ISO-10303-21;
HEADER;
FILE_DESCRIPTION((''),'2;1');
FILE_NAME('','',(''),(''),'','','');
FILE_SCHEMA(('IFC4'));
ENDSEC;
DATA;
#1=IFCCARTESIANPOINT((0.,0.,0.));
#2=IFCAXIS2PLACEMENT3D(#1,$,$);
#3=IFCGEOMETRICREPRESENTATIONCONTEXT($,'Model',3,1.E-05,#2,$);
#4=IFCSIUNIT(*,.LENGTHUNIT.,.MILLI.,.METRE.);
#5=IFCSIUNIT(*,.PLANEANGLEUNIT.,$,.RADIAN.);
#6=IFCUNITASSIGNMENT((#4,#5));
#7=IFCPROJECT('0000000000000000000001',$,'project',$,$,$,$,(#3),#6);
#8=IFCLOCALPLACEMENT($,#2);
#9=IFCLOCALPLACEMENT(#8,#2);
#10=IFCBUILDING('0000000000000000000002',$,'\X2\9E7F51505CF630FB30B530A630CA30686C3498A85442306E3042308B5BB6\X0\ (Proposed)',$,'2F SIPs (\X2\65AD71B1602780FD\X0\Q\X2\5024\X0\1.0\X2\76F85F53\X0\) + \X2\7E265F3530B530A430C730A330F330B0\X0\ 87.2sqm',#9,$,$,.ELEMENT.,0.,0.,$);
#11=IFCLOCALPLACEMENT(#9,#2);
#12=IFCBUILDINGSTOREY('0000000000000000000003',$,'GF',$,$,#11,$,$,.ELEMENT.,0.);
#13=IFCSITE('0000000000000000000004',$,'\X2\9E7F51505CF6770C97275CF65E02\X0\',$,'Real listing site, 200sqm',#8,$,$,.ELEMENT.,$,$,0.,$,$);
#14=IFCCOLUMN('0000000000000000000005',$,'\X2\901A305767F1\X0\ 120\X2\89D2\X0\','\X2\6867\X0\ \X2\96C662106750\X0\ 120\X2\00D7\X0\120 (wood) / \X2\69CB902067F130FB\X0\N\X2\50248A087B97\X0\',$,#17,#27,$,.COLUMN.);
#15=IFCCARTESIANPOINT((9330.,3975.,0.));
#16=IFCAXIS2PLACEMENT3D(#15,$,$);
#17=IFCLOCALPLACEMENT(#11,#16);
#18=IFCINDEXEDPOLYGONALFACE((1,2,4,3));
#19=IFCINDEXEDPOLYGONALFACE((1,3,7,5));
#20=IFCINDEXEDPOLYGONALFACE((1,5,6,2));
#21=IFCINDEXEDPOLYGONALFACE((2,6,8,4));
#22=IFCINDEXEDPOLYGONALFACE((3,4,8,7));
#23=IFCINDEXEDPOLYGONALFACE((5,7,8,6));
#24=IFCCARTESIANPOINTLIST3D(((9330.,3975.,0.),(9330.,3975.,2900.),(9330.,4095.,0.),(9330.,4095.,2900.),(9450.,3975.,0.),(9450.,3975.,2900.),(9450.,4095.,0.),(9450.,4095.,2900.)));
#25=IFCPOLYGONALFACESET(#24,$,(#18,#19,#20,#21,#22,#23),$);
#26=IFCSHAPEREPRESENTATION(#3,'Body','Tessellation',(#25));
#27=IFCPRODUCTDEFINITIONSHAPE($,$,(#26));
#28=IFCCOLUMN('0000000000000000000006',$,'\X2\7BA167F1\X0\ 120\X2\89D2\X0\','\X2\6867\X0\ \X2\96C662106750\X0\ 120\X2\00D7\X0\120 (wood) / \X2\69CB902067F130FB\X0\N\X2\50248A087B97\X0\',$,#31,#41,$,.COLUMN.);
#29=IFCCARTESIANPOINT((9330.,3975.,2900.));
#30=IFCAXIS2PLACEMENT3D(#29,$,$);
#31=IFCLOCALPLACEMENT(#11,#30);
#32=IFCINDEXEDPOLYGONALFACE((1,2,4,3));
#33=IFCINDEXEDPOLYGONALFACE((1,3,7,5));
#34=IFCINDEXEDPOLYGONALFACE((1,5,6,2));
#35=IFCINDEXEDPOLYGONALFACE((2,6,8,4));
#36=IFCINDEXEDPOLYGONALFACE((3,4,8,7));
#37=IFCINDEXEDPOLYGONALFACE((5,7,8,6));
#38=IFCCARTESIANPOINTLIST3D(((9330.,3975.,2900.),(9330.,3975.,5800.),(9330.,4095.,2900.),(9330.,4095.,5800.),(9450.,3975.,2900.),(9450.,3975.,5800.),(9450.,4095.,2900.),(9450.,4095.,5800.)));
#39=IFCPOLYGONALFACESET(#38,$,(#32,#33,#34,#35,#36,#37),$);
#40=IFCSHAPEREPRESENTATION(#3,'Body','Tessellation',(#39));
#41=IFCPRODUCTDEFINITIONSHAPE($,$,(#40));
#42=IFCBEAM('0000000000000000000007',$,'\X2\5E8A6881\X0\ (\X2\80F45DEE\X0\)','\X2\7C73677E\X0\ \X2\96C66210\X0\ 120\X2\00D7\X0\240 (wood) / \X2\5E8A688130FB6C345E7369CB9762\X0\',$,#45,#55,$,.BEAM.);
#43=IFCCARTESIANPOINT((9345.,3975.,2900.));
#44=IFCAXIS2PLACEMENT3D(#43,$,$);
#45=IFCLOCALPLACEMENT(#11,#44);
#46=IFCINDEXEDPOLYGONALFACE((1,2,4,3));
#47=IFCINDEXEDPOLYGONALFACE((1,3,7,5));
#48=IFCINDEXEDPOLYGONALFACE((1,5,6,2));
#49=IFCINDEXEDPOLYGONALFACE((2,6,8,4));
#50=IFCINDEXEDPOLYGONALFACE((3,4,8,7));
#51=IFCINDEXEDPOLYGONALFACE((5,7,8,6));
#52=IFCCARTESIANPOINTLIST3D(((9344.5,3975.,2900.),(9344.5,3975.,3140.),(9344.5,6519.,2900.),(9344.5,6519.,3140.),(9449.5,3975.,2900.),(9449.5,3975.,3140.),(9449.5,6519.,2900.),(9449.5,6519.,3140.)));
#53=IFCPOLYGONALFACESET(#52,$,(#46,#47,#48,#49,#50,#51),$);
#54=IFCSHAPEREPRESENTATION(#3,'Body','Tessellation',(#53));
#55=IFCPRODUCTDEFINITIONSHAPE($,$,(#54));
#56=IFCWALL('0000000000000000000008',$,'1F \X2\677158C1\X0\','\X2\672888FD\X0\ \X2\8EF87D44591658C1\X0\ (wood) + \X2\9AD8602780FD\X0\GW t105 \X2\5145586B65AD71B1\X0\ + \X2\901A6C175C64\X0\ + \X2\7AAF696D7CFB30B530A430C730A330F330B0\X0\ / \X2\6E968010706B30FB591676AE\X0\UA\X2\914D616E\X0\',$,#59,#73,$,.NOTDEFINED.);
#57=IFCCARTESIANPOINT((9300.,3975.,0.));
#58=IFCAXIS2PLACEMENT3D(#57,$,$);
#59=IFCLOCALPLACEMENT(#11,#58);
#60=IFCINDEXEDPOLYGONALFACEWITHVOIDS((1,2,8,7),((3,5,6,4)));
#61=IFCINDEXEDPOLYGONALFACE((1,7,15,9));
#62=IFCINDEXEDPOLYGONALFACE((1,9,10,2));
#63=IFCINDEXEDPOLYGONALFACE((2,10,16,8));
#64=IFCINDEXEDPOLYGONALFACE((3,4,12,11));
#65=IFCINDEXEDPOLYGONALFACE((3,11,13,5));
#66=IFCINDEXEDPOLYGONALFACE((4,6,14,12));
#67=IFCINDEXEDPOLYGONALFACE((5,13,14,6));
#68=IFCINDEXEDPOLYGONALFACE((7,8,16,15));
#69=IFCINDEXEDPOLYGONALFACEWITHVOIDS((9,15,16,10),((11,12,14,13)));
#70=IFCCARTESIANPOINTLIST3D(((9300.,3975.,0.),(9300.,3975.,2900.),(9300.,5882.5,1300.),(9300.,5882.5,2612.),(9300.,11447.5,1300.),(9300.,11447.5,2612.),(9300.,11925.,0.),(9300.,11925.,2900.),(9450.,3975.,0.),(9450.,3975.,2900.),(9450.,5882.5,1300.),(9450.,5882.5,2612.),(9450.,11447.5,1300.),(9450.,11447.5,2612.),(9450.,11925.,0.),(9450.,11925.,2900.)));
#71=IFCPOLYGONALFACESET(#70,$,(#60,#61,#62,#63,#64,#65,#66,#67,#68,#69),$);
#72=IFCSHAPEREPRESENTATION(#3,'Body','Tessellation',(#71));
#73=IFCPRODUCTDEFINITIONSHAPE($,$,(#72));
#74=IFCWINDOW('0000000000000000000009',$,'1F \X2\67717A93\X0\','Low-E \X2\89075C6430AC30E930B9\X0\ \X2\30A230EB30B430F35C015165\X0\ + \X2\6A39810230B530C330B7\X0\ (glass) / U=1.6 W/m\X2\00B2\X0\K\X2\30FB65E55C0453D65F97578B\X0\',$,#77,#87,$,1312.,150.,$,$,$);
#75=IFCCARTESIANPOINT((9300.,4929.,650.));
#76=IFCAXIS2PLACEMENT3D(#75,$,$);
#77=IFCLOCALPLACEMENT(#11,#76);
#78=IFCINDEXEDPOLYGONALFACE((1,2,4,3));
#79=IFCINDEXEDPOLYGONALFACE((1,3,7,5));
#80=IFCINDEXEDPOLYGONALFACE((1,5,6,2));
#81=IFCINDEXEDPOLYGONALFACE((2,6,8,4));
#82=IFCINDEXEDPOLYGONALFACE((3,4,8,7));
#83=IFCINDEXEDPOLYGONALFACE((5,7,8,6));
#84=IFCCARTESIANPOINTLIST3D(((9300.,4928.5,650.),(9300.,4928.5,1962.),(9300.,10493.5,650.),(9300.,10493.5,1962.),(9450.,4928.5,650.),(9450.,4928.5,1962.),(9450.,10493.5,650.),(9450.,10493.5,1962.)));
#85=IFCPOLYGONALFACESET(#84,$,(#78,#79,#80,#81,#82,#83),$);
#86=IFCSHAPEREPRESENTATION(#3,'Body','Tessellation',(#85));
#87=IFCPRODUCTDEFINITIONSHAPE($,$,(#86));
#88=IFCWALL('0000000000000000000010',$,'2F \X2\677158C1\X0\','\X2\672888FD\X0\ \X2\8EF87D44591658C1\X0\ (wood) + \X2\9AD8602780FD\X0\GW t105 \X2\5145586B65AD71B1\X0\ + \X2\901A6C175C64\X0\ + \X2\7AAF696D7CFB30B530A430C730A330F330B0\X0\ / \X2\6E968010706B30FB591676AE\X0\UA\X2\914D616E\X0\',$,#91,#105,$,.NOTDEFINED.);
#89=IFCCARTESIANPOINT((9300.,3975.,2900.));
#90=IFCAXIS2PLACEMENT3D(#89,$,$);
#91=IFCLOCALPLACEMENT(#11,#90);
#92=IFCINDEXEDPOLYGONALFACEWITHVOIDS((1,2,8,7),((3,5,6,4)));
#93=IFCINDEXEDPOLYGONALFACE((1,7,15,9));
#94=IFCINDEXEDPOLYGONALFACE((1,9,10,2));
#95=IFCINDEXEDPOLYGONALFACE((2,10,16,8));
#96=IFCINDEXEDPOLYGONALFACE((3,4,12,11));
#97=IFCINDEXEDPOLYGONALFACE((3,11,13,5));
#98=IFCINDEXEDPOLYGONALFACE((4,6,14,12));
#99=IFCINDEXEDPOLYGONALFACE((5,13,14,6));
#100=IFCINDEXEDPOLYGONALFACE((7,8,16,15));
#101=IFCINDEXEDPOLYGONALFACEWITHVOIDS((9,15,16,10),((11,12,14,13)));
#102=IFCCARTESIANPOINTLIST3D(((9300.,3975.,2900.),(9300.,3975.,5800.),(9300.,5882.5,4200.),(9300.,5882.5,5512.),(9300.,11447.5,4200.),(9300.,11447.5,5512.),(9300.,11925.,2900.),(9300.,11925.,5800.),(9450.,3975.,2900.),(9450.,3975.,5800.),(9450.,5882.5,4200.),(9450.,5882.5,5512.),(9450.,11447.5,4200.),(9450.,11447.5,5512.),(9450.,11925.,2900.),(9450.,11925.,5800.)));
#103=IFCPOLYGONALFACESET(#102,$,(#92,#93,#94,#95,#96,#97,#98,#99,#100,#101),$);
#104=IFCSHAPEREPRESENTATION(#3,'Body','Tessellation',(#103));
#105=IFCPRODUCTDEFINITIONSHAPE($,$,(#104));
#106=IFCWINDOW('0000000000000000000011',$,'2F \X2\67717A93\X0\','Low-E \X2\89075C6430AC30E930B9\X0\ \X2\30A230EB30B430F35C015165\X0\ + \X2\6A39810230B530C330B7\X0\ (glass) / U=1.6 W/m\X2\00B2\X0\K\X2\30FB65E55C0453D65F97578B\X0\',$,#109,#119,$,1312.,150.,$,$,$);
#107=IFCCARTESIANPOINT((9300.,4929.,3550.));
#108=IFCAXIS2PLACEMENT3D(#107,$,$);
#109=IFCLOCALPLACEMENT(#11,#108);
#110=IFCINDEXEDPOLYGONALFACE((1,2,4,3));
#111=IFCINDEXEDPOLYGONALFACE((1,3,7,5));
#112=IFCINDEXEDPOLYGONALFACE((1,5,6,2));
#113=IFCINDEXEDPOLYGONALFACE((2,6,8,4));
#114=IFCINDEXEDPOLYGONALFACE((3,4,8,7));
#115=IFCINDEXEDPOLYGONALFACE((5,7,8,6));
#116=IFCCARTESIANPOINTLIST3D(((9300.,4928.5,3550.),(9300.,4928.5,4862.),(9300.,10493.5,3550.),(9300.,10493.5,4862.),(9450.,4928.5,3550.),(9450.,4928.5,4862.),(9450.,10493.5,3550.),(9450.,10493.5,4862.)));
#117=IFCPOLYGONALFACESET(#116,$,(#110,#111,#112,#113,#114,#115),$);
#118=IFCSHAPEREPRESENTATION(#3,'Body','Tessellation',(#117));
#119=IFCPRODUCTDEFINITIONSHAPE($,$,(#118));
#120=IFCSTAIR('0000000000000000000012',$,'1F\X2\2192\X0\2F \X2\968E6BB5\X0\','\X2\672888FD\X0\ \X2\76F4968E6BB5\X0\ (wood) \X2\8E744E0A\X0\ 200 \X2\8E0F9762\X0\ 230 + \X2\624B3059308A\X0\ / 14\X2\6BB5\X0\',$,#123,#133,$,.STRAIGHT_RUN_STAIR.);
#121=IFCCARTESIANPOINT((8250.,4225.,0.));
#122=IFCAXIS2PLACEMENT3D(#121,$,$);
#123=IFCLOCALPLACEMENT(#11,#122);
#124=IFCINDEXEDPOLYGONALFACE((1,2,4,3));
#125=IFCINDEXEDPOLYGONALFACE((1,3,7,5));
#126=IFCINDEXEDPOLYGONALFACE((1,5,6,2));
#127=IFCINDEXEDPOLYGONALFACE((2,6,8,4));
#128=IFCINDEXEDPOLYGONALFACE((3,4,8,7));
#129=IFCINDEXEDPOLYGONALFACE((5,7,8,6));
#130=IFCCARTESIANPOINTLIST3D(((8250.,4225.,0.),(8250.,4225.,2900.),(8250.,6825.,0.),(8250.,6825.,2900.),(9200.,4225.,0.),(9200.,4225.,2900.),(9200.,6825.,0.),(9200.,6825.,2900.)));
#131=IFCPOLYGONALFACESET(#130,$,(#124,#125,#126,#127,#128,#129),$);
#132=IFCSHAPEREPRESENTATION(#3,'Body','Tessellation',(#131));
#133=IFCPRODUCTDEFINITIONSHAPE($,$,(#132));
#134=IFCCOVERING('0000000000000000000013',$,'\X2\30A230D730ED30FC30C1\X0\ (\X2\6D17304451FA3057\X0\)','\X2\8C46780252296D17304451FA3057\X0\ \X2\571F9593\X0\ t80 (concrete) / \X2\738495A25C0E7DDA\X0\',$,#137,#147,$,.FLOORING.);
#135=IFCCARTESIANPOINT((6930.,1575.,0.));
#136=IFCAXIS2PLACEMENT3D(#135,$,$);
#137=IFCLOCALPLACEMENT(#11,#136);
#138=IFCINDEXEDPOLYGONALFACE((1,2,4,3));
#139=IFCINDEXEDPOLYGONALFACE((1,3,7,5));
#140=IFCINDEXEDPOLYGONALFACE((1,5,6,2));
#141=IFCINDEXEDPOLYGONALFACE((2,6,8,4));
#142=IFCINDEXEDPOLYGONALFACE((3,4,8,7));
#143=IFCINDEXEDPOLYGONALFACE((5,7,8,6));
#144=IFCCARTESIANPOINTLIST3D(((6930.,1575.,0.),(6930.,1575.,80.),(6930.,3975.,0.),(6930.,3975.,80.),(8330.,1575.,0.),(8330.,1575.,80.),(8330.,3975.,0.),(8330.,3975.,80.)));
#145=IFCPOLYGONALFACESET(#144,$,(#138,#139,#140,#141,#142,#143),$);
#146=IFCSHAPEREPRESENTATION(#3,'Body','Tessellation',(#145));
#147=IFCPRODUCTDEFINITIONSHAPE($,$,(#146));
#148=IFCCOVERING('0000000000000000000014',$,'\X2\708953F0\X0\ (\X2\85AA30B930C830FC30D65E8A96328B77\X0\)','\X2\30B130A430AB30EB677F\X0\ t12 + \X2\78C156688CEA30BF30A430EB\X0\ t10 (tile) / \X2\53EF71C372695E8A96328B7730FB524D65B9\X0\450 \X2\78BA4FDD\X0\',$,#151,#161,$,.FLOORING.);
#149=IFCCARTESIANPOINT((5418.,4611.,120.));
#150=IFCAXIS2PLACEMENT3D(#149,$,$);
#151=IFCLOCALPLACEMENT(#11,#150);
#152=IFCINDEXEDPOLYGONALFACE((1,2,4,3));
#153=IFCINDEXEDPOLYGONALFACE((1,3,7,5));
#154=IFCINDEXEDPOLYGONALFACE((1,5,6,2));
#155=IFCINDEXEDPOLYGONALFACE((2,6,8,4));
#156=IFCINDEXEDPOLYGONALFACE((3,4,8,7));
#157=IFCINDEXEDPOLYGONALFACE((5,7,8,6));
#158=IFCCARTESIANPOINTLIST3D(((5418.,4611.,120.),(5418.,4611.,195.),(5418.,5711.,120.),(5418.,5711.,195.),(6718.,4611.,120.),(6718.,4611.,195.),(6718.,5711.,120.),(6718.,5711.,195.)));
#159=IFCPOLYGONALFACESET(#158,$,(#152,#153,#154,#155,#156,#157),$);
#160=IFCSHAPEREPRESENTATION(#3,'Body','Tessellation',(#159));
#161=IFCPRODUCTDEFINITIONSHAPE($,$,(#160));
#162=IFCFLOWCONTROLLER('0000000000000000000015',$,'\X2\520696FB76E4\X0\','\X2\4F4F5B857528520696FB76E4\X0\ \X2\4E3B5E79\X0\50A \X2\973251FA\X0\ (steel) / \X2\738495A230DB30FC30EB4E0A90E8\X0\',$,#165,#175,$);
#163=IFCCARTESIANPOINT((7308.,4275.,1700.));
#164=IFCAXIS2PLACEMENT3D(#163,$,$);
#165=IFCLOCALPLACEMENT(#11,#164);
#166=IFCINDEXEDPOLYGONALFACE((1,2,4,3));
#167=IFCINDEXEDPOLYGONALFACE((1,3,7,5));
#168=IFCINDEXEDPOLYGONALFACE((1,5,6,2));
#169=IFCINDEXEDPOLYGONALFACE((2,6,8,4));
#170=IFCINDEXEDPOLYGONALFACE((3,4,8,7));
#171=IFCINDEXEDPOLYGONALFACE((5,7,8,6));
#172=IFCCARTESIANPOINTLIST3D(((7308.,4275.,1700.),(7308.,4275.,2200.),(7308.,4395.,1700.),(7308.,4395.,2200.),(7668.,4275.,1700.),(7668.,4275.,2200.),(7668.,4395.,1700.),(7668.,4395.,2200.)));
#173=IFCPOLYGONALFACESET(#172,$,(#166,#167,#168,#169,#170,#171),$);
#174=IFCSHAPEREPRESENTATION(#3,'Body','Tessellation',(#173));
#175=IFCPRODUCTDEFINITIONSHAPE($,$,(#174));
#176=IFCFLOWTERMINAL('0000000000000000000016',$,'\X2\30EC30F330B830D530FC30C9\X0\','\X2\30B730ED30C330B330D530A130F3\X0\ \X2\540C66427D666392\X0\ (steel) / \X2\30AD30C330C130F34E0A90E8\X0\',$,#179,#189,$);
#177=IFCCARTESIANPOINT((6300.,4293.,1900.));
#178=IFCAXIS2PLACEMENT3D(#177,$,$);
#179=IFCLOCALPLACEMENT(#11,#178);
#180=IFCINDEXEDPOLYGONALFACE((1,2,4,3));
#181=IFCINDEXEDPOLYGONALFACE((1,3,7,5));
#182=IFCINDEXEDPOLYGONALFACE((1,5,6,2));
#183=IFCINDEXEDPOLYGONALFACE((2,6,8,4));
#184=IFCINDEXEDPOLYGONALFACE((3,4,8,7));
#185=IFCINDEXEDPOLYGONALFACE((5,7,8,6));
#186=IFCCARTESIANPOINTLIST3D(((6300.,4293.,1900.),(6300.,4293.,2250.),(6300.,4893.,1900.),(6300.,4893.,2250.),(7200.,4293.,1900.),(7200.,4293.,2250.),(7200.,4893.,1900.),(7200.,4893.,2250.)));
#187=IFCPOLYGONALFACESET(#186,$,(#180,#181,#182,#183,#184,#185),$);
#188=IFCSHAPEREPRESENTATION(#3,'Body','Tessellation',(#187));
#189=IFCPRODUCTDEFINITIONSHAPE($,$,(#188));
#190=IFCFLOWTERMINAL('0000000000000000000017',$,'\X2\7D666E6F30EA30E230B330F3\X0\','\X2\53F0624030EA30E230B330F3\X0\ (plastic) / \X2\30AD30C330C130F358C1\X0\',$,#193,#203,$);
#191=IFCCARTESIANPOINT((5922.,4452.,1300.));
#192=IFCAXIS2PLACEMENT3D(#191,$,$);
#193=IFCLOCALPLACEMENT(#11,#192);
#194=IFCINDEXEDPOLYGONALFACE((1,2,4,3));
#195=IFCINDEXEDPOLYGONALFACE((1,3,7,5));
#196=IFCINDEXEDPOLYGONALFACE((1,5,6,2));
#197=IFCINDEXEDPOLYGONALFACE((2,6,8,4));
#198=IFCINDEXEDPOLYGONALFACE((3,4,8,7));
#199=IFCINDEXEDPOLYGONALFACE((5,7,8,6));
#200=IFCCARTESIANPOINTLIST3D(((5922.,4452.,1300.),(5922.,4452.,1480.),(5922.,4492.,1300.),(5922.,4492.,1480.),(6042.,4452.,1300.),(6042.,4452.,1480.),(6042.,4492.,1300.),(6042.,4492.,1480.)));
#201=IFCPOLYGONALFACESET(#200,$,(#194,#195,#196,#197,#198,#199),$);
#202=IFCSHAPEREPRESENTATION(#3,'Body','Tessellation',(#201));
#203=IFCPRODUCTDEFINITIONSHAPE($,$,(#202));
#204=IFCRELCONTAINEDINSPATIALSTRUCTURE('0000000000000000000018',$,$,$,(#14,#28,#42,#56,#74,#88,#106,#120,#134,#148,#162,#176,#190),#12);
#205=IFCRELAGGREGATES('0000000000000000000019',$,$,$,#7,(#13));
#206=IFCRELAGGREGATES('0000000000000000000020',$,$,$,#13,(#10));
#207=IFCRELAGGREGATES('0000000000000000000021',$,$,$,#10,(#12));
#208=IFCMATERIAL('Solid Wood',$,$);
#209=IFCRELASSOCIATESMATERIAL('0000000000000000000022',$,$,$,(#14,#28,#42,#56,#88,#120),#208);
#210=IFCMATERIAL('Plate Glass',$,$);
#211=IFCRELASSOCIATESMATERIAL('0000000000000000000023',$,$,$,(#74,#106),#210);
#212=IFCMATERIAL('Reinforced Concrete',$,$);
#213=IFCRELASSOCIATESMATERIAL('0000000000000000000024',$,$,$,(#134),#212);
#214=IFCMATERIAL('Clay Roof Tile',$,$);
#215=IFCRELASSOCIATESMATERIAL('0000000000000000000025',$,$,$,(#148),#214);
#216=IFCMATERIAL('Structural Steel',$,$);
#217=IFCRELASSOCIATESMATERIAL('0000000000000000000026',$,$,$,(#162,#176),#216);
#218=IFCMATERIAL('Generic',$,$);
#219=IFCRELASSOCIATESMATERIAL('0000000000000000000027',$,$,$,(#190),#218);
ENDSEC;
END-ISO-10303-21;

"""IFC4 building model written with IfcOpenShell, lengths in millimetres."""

from ifc_helpers import new_model, si_unit, frame, frame_2d, origin, place, context, project, spatial, rectangle, extrude, material, element, fill, save


model = new_model("IFC4")

# Units and contexts
model_context = context("Model", 3, precision=1e-05, world=origin())
ifc_project = project(units=[si_unit("LENGTHUNIT", "METRE", prefix="MILLI"), si_unit("PLANEANGLEUNIT", "RADIAN")], contexts=[model_context])

# Site, building, storey
site_placement = place(None, origin())
site = spatial("IfcSite", under=ifc_project, at=site_placement, Name="鹿児島県霧島市", ObjectType="Real listing site, 200sqm", CompositionType="ELEMENT", RefElevation=0.0)
building_placement = place(site_placement, origin())
building = spatial("IfcBuilding", under=site, at=building_placement, Name="鹿児島・サウナと水風呂のある家 (Proposed)", ObjectType="2F SIPs (断熱性能Q値1.0相当) + 縦張サイディング 87.2sqm", CompositionType="ELEMENT", ElevationOfRefHeight=0.0, ElevationOfTerrain=0.0)
storey_placement = place(building_placement, origin())
storey = spatial("IfcBuildingStorey", under=building, at=storey_placement, Name="GF", CompositionType="ELEMENT", Elevation=0.0)

# Columns
ifc_material_1 = material(Name="Solid Wood")
column_1_placement = place(storey_placement, frame((9330.0, 3975.0, 0.0)))
element("IfcColumn", 1, at=column_1_placement, inside=storey, material=ifc_material_1, Name="通し柱 120角", Description="桧 集成材 120×120 (wood) / 構造柱・N値計算", PredefinedType="COLUMN", context=model_context, shape_type="SweptSolid", body=[
    extrude(rectangle(XDim=120.0, YDim=120.0, at=frame_2d((60.0, 60.0))), frame((9330.0, 3975.0, 0.0)), (0.0, 0.0, 1.0), 2900.0),
])
column_2_placement = place(storey_placement, frame((9330.0, 3975.0, 2900.0)))
element("IfcColumn", 2, at=column_2_placement, inside=storey, material=ifc_material_1, Name="管柱 120角", Description="桧 集成材 120×120 (wood) / 構造柱・N値計算", PredefinedType="COLUMN", context=model_context, shape_type="SweptSolid", body=[
    extrude(rectangle(XDim=120.0, YDim=120.0, at=frame_2d((60.0, 60.0))), frame((9330.0, 3975.0, 2900.0)), (0.0, 0.0, 1.0), 2900.0),
])

# Beam
beam_1_placement = place(storey_placement, frame((9345.0, 3975.0, 2900.0)))
element("IfcBeam", 3, at=beam_1_placement, inside=storey, material=ifc_material_1, Name="床梁 (胴差)", Description="米松 集成 120×240 (wood) / 床梁・水平構面", PredefinedType="BEAM", context=model_context, shape_type="SweptSolid", body=[
    extrude(rectangle(XDim=105.0, YDim=2544.0, at=frame_2d((52.0, 1272.0))), frame((9345.0, 3975.0, 2900.0)), (0.0, 0.0, 1.0), 240.0),
])

# Wall, opening, window
wall_1_placement = place(storey_placement, frame((9300.0, 3975.0, 0.0)))
wall_1 = element("IfcWall", 4, at=wall_1_placement, inside=storey, material=ifc_material_1, Name="1F 東壁", Description="木製 軸組外壁 (wood) + 高性能GW t105 充填断熱 + 通気層 + 窯業系サイディング / 準耐火・外皮UA配慮", PredefinedType="NOTDEFINED", context=model_context, shape_type="SweptSolid", body=[
    extrude(rectangle(XDim=150.0, YDim=7950.0, at=frame_2d((75.0, 3975.0))), frame((9300.0, 3975.0, 0.0)), (0.0, 0.0, 1.0), 2900.0),
])
opening_1_placement = place(storey_placement, frame((9300.0, 4929.0, 650.0)))
opening_1 = element("IfcOpeningElement", 5, at=opening_1_placement, cuts=wall_1, PredefinedType="NOTDEFINED", context=model_context, shape_type="SweptSolid", body=[
    extrude(rectangle(XDim=150.0, YDim=5565.0, at=frame_2d((75.0, 2782.0))), frame((9300.0, 4929.0, 650.0)), (0.0, 0.0, 1.0), 1312.0),
])
ifc_material_2 = material(Name="Plate Glass")
window_1_placement = place(storey_placement, frame((9300.0, 4929.0, 650.0)))
window_1 = element("IfcWindow", 6, at=window_1_placement, inside=storey, material=ifc_material_2, Name="1F 東窓", Description="Low-E 複層ガラス アルゴン封入 + 樹脂サッシ (glass) / U=1.6 W/m²K・日射取得型", OverallHeight=1312.0, OverallWidth=150.0, context=model_context, shape_type="SweptSolid", body=[
    extrude(rectangle(XDim=150.0, YDim=5565.0, at=frame_2d((75.0, 2782.0))), frame((9300.0, 4929.0, 650.0)), (0.0, 0.0, 1.0), 1312.0),
])
fill(opening_1, window_1)

# Wall, opening, window
wall_2_placement = place(storey_placement, frame((9300.0, 3975.0, 2900.0)))
wall_2 = element("IfcWall", 7, at=wall_2_placement, inside=storey, material=ifc_material_1, Name="2F 東壁", Description="木製 軸組外壁 (wood) + 高性能GW t105 充填断熱 + 通気層 + 窯業系サイディング / 準耐火・外皮UA配慮", PredefinedType="NOTDEFINED", context=model_context, shape_type="SweptSolid", body=[
    extrude(rectangle(XDim=150.0, YDim=7950.0, at=frame_2d((75.0, 3975.0))), frame((9300.0, 3975.0, 2900.0)), (0.0, 0.0, 1.0), 2900.0),
])
opening_2_placement = place(storey_placement, frame((9300.0, 4929.0, 3550.0)))
opening_2 = element("IfcOpeningElement", 8, at=opening_2_placement, cuts=wall_2, PredefinedType="NOTDEFINED", context=model_context, shape_type="SweptSolid", body=[
    extrude(rectangle(XDim=150.0, YDim=5565.0, at=frame_2d((75.0, 2782.0))), frame((9300.0, 4929.0, 3550.0)), (0.0, 0.0, 1.0), 1312.0),
])
window_2_placement = place(storey_placement, frame((9300.0, 4929.0, 3550.0)))
window_2 = element("IfcWindow", 9, at=window_2_placement, inside=storey, material=ifc_material_2, Name="2F 東窓", Description="Low-E 複層ガラス アルゴン封入 + 樹脂サッシ (glass) / U=1.6 W/m²K・日射取得型", OverallHeight=1312.0, OverallWidth=150.0, context=model_context, shape_type="SweptSolid", body=[
    extrude(rectangle(XDim=150.0, YDim=5565.0, at=frame_2d((75.0, 2782.0))), frame((9300.0, 4929.0, 3550.0)), (0.0, 0.0, 1.0), 1312.0),
])
fill(opening_2, window_2)

# Stair
stair_placement = place(storey_placement, frame((8250.0, 4225.0, 0.0)))
element("IfcStair", 10, at=stair_placement, inside=storey, material=ifc_material_1, Name="1F→2F 階段", Description="木製 直階段 (wood) 蹴上 200 踏面 230 + 手すり / 14段", PredefinedType="STRAIGHT_RUN_STAIR", context=model_context, shape_type="SweptSolid", body=[
    extrude(rectangle(XDim=950.0, YDim=2600.0, at=frame_2d((475.0, 1300.0))), frame((8250.0, 4225.0, 0.0)), (0.0, 0.0, 1.0), 2900.0),
])

# Coverings
ifc_material_3 = material(Name="Reinforced Concrete")
covering_1_placement = place(storey_placement, frame((6930.0, 1575.0, 0.0)))
element("IfcCovering", 11, at=covering_1_placement, inside=storey, material=ifc_material_3, Name="アプローチ (洗い出し)", Description="豆砂利洗い出し 土間 t80 (concrete) / 玄関導線", PredefinedType="FLOORING", context=model_context, shape_type="SweptSolid", body=[
    extrude(rectangle(XDim=1400.0, YDim=2400.0, at=frame_2d((700.0, 1200.0))), frame((6930.0, 1575.0, 0.0)), (0.0, 0.0, 1.0), 80.0),
])
ifc_material_4 = material(Name="Clay Roof Tile")
covering_2_placement = place(storey_placement, frame((5418.0, 4611.0, 120.0)))
element("IfcCovering", 12, at=covering_2_placement, inside=storey, material=ifc_material_4, Name="炉台 (薪ストーブ床防護)", Description="ケイカル板 t12 + 磁器質タイル t10 (tile) / 可燃物床防護・前方450 確保", PredefinedType="FLOORING", context=model_context, shape_type="SweptSolid", body=[
    extrude(rectangle(XDim=1300.0, YDim=1100.0, at=frame_2d((650.0, 550.0))), frame((5418.0, 4611.0, 120.0)), (0.0, 0.0, 1.0), 75.0),
])

# Flow controller
ifc_material_5 = material(Name="Structural Steel")
flow_controller_placement = place(storey_placement, frame((7308.0, 4275.0, 1700.0)))
element("IfcFlowController", 13, at=flow_controller_placement, inside=storey, material=ifc_material_5, Name="分電盤", Description="住宅用分電盤 主幹50A 露出 (steel) / 玄関ホール上部", context=model_context, shape_type="SweptSolid", body=[
    extrude(rectangle(XDim=360.0, YDim=120.0, at=frame_2d((180.0, 60.0))), frame((7308.0, 4275.0, 1700.0)), (0.0, 0.0, 1.0), 500.0),
])

# Flow terminals
flow_terminal_1_placement = place(storey_placement, frame((6300.0, 4293.0, 1900.0)))
element("IfcFlowTerminal", 14, at=flow_terminal_1_placement, inside=storey, material=ifc_material_5, Name="レンジフード", Description="シロッコファン 同時給排 (steel) / キッチン上部", context=model_context, shape_type="SweptSolid", body=[
    extrude(rectangle(XDim=900.0, YDim=600.0, at=frame_2d((450.0, 300.0))), frame((6300.0, 4293.0, 1900.0)), (0.0, 0.0, 1.0), 350.0),
])
ifc_material_6 = material(Name="Generic")
flow_terminal_2_placement = place(storey_placement, frame((5922.0, 4452.0, 1300.0)))
element("IfcFlowTerminal", 15, at=flow_terminal_2_placement, inside=storey, material=ifc_material_6, Name="給湯リモコン", Description="台所リモコン (plastic) / キッチン壁", context=model_context, shape_type="SweptSolid", body=[
    extrude(rectangle(XDim=120.0, YDim=40.0, at=frame_2d((60.0, 20.0))), frame((5922.0, 4452.0, 1300.0)), (0.0, 0.0, 1.0), 180.0),
])

save(model, "model.ifc")
